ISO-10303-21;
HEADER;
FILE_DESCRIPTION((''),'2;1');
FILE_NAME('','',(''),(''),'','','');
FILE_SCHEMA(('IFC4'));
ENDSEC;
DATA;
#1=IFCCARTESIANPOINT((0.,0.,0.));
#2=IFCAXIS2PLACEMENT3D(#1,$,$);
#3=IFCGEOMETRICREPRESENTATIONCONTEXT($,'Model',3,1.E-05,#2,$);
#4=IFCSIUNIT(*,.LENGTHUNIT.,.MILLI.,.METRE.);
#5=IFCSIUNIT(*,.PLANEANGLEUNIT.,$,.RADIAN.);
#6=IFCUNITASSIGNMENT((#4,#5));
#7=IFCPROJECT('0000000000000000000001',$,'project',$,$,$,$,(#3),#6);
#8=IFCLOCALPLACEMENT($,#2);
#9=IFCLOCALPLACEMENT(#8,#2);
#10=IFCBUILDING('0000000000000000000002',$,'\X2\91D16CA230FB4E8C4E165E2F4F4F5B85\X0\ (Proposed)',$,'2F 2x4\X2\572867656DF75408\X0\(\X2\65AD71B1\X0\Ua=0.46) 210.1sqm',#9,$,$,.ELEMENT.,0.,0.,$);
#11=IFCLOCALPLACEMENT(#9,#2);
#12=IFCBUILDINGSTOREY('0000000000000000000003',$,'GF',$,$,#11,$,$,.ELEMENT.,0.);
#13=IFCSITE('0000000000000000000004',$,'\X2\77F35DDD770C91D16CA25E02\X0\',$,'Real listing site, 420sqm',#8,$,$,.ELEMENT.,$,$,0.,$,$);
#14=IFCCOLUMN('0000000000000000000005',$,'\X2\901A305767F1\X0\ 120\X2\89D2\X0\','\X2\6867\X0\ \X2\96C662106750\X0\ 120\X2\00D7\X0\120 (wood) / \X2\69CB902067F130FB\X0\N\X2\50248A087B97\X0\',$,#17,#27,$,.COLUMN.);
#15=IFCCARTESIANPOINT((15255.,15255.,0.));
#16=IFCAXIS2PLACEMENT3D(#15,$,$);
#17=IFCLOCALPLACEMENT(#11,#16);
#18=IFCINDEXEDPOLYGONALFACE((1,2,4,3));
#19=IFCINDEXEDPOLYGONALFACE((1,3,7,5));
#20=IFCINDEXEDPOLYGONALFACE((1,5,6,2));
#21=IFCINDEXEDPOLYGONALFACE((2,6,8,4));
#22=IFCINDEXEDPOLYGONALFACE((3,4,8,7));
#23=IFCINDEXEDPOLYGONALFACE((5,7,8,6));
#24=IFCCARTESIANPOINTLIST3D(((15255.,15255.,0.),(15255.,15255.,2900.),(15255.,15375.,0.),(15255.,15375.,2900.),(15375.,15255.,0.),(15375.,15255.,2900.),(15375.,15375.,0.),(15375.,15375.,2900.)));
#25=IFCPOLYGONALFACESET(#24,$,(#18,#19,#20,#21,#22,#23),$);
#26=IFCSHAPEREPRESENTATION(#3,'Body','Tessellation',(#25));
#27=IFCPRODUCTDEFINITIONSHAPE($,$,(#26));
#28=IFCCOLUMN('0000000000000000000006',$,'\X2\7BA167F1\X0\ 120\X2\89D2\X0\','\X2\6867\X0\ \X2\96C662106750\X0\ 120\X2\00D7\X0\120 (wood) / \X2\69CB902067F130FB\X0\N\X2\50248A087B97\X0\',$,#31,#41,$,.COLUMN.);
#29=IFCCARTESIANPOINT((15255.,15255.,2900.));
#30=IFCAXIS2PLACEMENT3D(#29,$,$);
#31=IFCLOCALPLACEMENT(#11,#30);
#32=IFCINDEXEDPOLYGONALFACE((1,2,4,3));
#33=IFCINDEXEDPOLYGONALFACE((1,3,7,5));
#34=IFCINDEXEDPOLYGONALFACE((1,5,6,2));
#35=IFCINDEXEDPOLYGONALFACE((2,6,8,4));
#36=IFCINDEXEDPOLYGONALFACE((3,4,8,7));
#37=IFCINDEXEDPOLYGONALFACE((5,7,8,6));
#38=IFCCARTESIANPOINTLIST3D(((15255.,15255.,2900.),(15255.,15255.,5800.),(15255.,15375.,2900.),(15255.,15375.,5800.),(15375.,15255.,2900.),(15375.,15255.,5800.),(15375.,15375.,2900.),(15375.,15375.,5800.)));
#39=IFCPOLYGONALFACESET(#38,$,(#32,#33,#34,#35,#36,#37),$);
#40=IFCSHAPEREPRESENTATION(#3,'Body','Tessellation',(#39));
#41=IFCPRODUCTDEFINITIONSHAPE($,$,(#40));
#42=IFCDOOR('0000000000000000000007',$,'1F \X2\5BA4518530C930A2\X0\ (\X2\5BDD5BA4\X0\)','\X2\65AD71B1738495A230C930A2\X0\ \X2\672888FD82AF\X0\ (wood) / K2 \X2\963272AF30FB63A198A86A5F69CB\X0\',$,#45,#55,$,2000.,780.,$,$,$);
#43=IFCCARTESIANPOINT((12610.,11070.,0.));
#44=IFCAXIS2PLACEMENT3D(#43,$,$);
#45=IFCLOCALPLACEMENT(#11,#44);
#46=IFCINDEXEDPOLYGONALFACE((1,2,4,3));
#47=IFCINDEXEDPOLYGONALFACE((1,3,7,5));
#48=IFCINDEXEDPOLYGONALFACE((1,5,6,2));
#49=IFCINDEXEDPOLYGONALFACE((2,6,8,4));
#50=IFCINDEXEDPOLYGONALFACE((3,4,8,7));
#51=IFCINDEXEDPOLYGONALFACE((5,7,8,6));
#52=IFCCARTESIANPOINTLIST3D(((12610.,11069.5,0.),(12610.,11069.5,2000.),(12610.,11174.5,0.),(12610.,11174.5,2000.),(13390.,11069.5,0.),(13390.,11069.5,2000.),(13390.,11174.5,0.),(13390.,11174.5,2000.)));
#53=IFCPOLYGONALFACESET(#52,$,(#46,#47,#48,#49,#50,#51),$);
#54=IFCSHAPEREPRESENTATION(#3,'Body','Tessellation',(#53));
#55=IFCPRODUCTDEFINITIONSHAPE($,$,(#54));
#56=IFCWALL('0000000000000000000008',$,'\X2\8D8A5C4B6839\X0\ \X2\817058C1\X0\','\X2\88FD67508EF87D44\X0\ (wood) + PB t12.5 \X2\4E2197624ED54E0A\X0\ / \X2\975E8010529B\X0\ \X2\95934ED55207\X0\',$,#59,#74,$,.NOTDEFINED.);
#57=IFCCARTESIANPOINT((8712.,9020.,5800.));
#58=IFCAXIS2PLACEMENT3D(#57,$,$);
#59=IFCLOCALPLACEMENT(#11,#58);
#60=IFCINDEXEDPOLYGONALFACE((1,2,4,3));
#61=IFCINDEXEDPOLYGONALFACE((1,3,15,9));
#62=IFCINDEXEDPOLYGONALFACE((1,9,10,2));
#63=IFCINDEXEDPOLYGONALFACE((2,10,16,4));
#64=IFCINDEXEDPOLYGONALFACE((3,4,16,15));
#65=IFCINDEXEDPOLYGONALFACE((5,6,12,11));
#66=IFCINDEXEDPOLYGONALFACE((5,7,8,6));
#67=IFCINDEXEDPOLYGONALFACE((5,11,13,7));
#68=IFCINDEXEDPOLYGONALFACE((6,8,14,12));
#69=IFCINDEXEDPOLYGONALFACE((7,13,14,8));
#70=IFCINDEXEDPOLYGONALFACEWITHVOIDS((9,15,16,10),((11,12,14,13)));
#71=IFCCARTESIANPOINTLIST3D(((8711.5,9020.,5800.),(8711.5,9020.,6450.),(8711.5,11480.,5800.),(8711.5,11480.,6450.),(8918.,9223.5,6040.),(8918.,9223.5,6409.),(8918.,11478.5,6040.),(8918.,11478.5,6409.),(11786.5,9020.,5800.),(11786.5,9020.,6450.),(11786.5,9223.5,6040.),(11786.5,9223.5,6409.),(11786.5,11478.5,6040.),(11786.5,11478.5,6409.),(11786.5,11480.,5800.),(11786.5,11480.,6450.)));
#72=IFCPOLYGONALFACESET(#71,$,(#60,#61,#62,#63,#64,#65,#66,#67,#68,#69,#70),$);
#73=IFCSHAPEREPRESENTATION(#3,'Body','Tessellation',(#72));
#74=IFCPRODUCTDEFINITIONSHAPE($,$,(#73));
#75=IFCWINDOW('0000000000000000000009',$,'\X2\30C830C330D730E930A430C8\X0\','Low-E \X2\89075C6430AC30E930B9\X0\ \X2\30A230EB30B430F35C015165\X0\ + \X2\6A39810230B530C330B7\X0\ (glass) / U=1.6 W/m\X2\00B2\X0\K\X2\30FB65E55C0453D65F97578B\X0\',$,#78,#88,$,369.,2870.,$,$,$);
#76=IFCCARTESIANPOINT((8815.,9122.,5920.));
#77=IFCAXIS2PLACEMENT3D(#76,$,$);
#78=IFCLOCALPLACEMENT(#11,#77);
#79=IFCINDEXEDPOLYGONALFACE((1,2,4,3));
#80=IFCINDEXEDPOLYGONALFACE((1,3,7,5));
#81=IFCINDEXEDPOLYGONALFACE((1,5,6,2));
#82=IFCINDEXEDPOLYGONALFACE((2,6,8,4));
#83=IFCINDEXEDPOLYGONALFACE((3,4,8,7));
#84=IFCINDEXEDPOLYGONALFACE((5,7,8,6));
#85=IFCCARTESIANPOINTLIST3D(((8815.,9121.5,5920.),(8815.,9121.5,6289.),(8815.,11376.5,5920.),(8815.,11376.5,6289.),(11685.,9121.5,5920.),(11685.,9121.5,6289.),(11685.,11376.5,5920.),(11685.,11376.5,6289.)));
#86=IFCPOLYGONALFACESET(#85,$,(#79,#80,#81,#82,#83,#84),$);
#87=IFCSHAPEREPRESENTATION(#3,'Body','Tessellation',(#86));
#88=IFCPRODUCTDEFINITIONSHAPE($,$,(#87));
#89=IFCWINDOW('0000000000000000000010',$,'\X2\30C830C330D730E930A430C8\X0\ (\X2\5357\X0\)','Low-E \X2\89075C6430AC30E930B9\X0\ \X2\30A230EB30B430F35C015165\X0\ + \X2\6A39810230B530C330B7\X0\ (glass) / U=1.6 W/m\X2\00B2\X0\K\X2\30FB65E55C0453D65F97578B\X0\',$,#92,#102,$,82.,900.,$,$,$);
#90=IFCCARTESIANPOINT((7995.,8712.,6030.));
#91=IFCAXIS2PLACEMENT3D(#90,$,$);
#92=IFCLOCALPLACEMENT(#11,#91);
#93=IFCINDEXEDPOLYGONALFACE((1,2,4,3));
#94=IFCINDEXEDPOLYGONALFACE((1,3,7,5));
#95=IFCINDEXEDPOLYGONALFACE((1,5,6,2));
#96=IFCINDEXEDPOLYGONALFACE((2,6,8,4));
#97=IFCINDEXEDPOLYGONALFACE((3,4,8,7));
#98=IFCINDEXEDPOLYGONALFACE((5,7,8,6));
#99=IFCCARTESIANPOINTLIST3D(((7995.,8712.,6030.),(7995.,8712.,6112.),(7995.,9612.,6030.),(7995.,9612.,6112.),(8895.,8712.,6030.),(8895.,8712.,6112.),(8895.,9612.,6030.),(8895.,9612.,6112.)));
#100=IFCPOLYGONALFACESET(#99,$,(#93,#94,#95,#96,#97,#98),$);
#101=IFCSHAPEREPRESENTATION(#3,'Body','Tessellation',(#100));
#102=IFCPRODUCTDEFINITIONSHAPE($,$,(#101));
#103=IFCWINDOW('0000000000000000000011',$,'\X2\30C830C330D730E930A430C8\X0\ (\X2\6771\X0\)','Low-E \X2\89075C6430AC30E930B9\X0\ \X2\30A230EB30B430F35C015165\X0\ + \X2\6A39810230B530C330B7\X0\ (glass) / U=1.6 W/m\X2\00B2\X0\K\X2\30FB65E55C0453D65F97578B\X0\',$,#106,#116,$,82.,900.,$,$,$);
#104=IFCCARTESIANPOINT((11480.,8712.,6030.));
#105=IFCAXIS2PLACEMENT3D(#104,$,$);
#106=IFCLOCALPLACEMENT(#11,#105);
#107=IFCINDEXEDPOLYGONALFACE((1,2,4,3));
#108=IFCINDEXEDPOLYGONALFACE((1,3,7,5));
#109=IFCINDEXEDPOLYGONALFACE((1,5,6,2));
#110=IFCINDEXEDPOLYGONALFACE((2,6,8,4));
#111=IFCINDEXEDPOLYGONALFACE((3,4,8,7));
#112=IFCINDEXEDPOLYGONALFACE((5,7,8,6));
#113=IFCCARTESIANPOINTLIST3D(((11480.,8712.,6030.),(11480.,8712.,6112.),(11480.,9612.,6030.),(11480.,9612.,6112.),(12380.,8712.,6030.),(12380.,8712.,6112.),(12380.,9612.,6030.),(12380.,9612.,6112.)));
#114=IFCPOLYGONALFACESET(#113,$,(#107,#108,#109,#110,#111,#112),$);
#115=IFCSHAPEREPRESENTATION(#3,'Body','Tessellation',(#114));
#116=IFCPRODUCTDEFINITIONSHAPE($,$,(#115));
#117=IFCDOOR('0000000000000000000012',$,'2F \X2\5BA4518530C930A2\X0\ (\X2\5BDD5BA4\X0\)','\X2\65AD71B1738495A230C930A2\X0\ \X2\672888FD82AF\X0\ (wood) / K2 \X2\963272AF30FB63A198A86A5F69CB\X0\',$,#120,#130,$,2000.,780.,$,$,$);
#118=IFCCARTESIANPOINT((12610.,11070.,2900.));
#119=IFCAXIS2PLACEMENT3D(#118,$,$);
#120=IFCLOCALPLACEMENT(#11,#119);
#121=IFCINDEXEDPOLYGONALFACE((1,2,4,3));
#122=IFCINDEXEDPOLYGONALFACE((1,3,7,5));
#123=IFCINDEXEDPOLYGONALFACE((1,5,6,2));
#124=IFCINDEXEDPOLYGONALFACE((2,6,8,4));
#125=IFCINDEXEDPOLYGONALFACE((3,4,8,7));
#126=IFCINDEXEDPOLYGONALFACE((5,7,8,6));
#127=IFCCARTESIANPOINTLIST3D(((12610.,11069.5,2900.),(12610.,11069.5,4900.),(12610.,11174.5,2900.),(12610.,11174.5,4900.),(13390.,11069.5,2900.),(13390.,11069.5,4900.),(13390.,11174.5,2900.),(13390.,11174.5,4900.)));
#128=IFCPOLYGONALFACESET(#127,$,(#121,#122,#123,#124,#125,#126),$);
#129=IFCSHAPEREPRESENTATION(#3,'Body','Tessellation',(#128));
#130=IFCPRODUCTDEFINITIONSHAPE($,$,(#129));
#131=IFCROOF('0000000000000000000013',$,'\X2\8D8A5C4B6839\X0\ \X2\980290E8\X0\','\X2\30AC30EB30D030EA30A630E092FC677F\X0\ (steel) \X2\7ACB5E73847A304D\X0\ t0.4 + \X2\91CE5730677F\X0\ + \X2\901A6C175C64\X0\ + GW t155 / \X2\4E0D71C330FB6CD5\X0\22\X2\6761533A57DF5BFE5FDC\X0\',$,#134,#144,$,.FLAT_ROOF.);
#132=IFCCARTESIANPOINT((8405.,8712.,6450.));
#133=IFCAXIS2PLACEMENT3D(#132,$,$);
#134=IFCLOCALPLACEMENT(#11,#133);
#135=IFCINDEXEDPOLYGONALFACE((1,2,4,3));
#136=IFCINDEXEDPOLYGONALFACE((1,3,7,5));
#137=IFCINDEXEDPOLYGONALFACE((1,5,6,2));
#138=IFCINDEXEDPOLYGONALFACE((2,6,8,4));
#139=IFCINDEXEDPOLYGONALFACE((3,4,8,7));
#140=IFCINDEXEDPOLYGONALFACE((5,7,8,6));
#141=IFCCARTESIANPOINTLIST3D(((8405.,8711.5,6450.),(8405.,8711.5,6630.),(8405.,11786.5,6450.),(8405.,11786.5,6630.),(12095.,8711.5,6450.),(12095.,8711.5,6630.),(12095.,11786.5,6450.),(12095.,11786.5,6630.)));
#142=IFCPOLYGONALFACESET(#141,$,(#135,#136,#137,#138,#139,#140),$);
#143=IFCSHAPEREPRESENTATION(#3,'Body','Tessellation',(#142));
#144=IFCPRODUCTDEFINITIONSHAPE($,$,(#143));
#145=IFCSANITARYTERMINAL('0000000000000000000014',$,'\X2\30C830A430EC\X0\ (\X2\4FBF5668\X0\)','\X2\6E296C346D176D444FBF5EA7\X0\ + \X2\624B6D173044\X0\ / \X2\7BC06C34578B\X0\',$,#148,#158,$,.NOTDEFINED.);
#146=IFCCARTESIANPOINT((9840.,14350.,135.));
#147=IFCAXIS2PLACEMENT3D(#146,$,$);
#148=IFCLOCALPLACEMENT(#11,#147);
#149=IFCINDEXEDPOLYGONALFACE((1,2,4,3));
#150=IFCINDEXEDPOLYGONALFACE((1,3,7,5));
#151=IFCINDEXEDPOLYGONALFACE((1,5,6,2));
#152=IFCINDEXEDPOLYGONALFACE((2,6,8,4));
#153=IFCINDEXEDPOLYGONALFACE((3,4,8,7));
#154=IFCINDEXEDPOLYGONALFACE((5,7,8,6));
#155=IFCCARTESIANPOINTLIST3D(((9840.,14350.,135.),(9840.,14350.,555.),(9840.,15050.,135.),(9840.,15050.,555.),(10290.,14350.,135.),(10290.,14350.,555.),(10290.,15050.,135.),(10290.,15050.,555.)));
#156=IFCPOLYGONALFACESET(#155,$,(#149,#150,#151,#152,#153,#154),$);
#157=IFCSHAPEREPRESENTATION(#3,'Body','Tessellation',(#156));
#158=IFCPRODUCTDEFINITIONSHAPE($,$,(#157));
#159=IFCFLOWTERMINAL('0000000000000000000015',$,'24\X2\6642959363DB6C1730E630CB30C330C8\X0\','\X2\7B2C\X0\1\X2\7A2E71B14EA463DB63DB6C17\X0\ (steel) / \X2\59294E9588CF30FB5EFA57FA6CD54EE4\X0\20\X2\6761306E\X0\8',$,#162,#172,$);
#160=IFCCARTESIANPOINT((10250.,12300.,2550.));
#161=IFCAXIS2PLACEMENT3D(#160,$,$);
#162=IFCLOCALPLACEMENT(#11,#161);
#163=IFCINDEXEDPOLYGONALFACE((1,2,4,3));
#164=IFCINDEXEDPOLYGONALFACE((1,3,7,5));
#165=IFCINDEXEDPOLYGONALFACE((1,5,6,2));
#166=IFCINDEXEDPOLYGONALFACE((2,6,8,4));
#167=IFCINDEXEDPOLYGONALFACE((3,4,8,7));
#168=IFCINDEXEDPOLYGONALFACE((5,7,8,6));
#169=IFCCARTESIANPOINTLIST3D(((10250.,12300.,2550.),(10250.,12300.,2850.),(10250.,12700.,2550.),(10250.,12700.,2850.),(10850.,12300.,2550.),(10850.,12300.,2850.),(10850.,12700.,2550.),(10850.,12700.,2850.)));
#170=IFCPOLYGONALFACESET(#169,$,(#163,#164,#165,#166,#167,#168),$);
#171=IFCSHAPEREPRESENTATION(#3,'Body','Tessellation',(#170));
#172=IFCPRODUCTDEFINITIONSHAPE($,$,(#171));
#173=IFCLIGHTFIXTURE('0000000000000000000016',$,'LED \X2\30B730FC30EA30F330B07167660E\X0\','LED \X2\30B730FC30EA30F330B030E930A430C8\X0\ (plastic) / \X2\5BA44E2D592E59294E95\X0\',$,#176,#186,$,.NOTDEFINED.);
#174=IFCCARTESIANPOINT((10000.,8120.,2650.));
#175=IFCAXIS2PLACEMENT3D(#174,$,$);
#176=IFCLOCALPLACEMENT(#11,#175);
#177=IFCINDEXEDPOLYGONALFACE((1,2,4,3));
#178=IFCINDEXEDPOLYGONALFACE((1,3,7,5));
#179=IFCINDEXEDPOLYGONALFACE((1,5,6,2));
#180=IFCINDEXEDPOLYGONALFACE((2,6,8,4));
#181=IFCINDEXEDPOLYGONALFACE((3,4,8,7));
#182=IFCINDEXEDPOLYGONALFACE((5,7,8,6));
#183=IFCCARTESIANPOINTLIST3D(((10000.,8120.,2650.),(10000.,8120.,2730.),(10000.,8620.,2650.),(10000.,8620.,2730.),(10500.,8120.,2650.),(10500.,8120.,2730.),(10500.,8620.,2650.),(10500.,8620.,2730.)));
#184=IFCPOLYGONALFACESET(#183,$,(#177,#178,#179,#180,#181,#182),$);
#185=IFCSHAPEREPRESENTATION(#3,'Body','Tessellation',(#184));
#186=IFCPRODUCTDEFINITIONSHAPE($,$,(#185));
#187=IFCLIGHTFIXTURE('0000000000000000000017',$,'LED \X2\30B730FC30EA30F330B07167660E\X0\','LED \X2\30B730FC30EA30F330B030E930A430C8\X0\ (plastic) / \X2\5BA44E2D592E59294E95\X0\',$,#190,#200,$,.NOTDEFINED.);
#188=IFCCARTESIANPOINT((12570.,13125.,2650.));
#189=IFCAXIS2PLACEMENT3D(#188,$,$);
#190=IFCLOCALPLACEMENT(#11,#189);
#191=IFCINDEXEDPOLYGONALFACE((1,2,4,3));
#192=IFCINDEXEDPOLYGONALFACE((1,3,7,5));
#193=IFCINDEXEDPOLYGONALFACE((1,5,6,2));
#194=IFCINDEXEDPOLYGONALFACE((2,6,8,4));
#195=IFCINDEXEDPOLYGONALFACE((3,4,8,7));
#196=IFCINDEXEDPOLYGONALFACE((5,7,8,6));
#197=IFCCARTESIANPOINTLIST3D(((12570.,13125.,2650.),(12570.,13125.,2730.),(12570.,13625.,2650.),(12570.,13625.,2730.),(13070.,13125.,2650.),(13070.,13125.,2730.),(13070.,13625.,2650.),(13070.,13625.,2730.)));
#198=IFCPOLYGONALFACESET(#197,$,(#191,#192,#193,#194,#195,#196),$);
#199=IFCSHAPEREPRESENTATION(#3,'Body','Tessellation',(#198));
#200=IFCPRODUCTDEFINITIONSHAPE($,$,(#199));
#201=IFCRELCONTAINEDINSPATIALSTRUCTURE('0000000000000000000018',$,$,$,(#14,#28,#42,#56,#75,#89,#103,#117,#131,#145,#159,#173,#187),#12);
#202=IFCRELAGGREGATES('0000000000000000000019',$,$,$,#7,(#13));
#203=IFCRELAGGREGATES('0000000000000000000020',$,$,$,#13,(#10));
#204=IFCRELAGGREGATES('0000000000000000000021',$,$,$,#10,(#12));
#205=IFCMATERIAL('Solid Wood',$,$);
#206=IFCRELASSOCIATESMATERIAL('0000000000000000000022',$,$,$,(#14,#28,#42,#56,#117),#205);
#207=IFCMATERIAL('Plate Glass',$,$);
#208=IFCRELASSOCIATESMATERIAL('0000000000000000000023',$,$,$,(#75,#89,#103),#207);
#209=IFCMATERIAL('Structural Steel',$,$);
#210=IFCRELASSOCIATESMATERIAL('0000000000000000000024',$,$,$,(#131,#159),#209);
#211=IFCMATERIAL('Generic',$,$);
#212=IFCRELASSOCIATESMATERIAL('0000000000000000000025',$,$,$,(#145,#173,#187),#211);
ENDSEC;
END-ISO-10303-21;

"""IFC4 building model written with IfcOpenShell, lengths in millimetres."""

from ifc_helpers import new_model, si_unit, frame, frame_2d, origin, place, context, project, spatial, rectangle, extrude, material, element, fill, save


model = new_model("IFC4")

# Units and contexts
model_context = context("Model", 3, precision=1e-05, world=origin())
ifc_project = project(units=[si_unit("LENGTHUNIT", "METRE", prefix="MILLI"), si_unit("PLANEANGLEUNIT", "RADIAN")], contexts=[model_context])

# Site, building, storey
site_placement = place(None, origin())
site = spatial("IfcSite", under=ifc_project, at=site_placement, Name="石川県金沢市", ObjectType="Real listing site, 420sqm", CompositionType="ELEMENT", RefElevation=0.0)
building_placement = place(site_placement, origin())
building = spatial("IfcBuilding", under=site, at=building_placement, Name="金沢・二世帯住宅 (Proposed)", ObjectType="2F 2x4在来混合(断熱Ua=0.46) 210.1sqm", CompositionType="ELEMENT", ElevationOfRefHeight=0.0, ElevationOfTerrain=0.0)
storey_placement = place(building_placement, origin())
storey = spatial("IfcBuildingStorey", under=building, at=storey_placement, Name="GF", CompositionType="ELEMENT", Elevation=0.0)

# Columns
ifc_material_1 = material(Name="Solid Wood")
column_1_placement = place(storey_placement, frame((15255.0, 15255.0, 0.0)))
element("IfcColumn", 1, at=column_1_placement, inside=storey, material=ifc_material_1, Name="通し柱 120角", Description="桧 集成材 120×120 (wood) / 構造柱・N値計算", PredefinedType="COLUMN", context=model_context, shape_type="SweptSolid", body=[
    extrude(rectangle(XDim=120.0, YDim=120.0, at=frame_2d((60.0, 60.0))), frame((15255.0, 15255.0, 0.0)), (0.0, 0.0, 1.0), 2900.0),
])
column_2_placement = place(storey_placement, frame((15255.0, 15255.0, 2900.0)))
element("IfcColumn", 2, at=column_2_placement, inside=storey, material=ifc_material_1, Name="管柱 120角", Description="桧 集成材 120×120 (wood) / 構造柱・N値計算", PredefinedType="COLUMN", context=model_context, shape_type="SweptSolid", body=[
    extrude(rectangle(XDim=120.0, YDim=120.0, at=frame_2d((60.0, 60.0))), frame((15255.0, 15255.0, 2900.0)), (0.0, 0.0, 1.0), 2900.0),
])

# Door
door_1_placement = place(storey_placement, frame((12610.0, 11070.0, 0.0)))
element("IfcDoor", 3, at=door_1_placement, inside=storey, material=ifc_material_1, Name="1F 室内ドア (寝室)", Description="断熱玄関ドア 木製芯 (wood) / K2 防犯・採風機構", OverallHeight=2000.0, OverallWidth=780.0, context=model_context, shape_type="SweptSolid", body=[
    extrude(rectangle(XDim=780.0, YDim=105.0, at=frame_2d((390.0, 52.0))), frame((12610.0, 11070.0, 0.0)), (0.0, 0.0, 1.0), 2000.0),
])

# Wall, openings, windows
wall_1_placement = place(storey_placement, frame((8712.0, 9020.0, 5800.0)))
wall_1 = element("IfcWall", 4, at=wall_1_placement, inside=storey, material=ifc_material_1, Name="越屋根 腰壁", Description="製材軸組 (wood) + PB t12.5 両面仕上 / 非耐力 間仕切", PredefinedType="NOTDEFINED", context=model_context, shape_type="SweptSolid", body=[
    extrude(rectangle(XDim=3075.0, YDim=2460.0, at=frame_2d((1537.0, 1230.0))), frame((8712.0, 9020.0, 5800.0)), (0.0, 0.0, 1.0), 650.0),
])
opening_1_placement = place(storey_placement, frame((8815.0, 9122.0, 5920.0)))
opening_1 = element("IfcOpeningElement", 5, at=opening_1_placement, cuts=wall_1, PredefinedType="NOTDEFINED", context=model_context, shape_type="SweptSolid", body=[
    extrude(rectangle(XDim=2870.0, YDim=2255.0, at=frame_2d((1435.0, 1127.0))), frame((8815.0, 9122.0, 5920.0)), (0.0, 0.0, 1.0), 369.0),
])
opening_2_placement = place(storey_placement, frame((7995.0, 8712.0, 6030.0)))
opening_2 = element("IfcOpeningElement", 6, at=opening_2_placement, cuts=wall_1, PredefinedType="NOTDEFINED", context=model_context, shape_type="SweptSolid", body=[
    extrude(rectangle(XDim=900.0, YDim=900.0, at=frame_2d((450.0, 450.0))), frame((7995.0, 8712.0, 6030.0)), (0.0, 0.0, 1.0), 82.0),
])
opening_3_placement = place(storey_placement, frame((11480.0, 8712.0, 6030.0)))
opening_3 = element("IfcOpeningElement", 7, at=opening_3_placement, cuts=wall_1, PredefinedType="NOTDEFINED", context=model_context, shape_type="SweptSolid", body=[
    extrude(rectangle(XDim=900.0, YDim=900.0, at=frame_2d((450.0, 450.0))), frame((11480.0, 8712.0, 6030.0)), (0.0, 0.0, 1.0), 82.0),
])
ifc_material_2 = material(Name="Plate Glass")
window_1_placement = place(storey_placement, frame((8815.0, 9122.0, 5920.0)))
window_1 = element("IfcWindow", 8, at=window_1_placement, inside=storey, material=ifc_material_2, Name="トップライト", Description="Low-E 複層ガラス アルゴン封入 + 樹脂サッシ (glass) / U=1.6 W/m²K・日射取得型", OverallHeight=369.0, OverallWidth=2870.0, context=model_context, shape_type="SweptSolid", body=[
    extrude(rectangle(XDim=2870.0, YDim=2255.0, at=frame_2d((1435.0, 1127.0))), frame((8815.0, 9122.0, 5920.0)), (0.0, 0.0, 1.0), 369.0),
])
fill(opening_1, window_1)
window_2_placement = place(storey_placement, frame((7995.0, 8712.0, 6030.0)))
window_2 = element("IfcWindow", 9, at=window_2_placement, inside=storey, material=ifc_material_2, Name="トップライト (南)", Description="Low-E 複層ガラス アルゴン封入 + 樹脂サッシ (glass) / U=1.6 W/m²K・日射取得型", OverallHeight=82.0, OverallWidth=900.0, context=model_context, shape_type="SweptSolid", body=[
    extrude(rectangle(XDim=900.0, YDim=900.0, at=frame_2d((450.0, 450.0))), frame((7995.0, 8712.0, 6030.0)), (0.0, 0.0, 1.0), 82.0),
])
fill(opening_2, window_2)
window_3_placement = place(storey_placement, frame((11480.0, 8712.0, 6030.0)))
window_3 = element("IfcWindow", 10, at=window_3_placement, inside=storey, material=ifc_material_2, Name="トップライト (東)", Description="Low-E 複層ガラス アルゴン封入 + 樹脂サッシ (glass) / U=1.6 W/m²K・日射取得型", OverallHeight=82.0, OverallWidth=900.0, context=model_context, shape_type="SweptSolid", body=[
    extrude(rectangle(XDim=900.0, YDim=900.0, at=frame_2d((450.0, 450.0))), frame((11480.0, 8712.0, 6030.0)), (0.0, 0.0, 1.0), 82.0),
])
fill(opening_3, window_3)

# Door
door_2_placement = place(storey_placement, frame((12610.0, 11070.0, 2900.0)))
element("IfcDoor", 11, at=door_2_placement, inside=storey, material=ifc_material_1, Name="2F 室内ドア (寝室)", Description="断熱玄関ドア 木製芯 (wood) / K2 防犯・採風機構", OverallHeight=2000.0, OverallWidth=780.0, context=model_context, shape_type="SweptSolid", body=[
    extrude(rectangle(XDim=780.0, YDim=105.0, at=frame_2d((390.0, 52.0))), frame((12610.0, 11070.0, 2900.0)), (0.0, 0.0, 1.0), 2000.0),
])

# Roof
ifc_material_3 = material(Name="Structural Steel")
roof_placement = place(storey_placement, frame((8405.0, 8712.0, 6450.0)))
element("IfcRoof", 12, at=roof_placement, inside=storey, material=ifc_material_3, Name="越屋根 頂部", Description="ガルバリウム鋼板 (steel) 立平葺き t0.4 + 野地板 + 通気層 + GW t155 / 不燃・法22条区域対応", PredefinedType="FLAT_ROOF", context=model_context, shape_type="SweptSolid", body=[
    extrude(rectangle(XDim=3690.0, YDim=3075.0, at=frame_2d((1845.0, 1537.0))), frame((8405.0, 8712.0, 6450.0)), (0.0, 0.0, 1.0), 180.0),
])

# Sanitary terminal
ifc_material_4 = material(Name="Generic")
sanitary_terminal_placement = place(storey_placement, frame((9840.0, 14350.0, 135.0)))
element("IfcSanitaryTerminal", 13, at=sanitary_terminal_placement, inside=storey, material=ifc_material_4, Name="トイレ (便器)", Description="温水洗浄便座 + 手洗い / 節水型", PredefinedType="NOTDEFINED", context=model_context, shape_type="SweptSolid", body=[
    extrude(rectangle(XDim=450.0, YDim=700.0, at=frame_2d((225.0, 350.0))), frame((9840.0, 14350.0, 135.0)), (0.0, 0.0, 1.0), 420.0),
])

# Flow terminal
flow_terminal_placement = place(storey_placement, frame((10250.0, 12300.0, 2550.0)))
element("IfcFlowTerminal", 14, at=flow_terminal_placement, inside=storey, material=ifc_material_3, Name="24時間換気ユニット", Description="第1種熱交換換気 (steel) / 天井裏・建基法令20条の8", context=model_context, shape_type="SweptSolid", body=[
    extrude(rectangle(XDim=600.0, YDim=400.0, at=frame_2d((300.0, 200.0))), frame((10250.0, 12300.0, 2550.0)), (0.0, 0.0, 1.0), 300.0),
])

# Light fixtures
light_fixture_1_placement = place(storey_placement, frame((10000.0, 8120.0, 2650.0)))
element("IfcLightFixture", 15, at=light_fixture_1_placement, inside=storey, material=ifc_material_4, Name="LED シーリング照明", Description="LED シーリングライト (plastic) / 室中央天井", PredefinedType="NOTDEFINED", context=model_context, shape_type="SweptSolid", body=[
    extrude(rectangle(XDim=500.0, YDim=500.0, at=frame_2d((250.0, 250.0))), frame((10000.0, 8120.0, 2650.0)), (0.0, 0.0, 1.0), 80.0),
])
light_fixture_2_placement = place(storey_placement, frame((12570.0, 13125.0, 2650.0)))
element("IfcLightFixture", 16, at=light_fixture_2_placement, inside=storey, material=ifc_material_4, Name="LED シーリング照明", Description="LED シーリングライト (plastic) / 室中央天井", PredefinedType="NOTDEFINED", context=model_context, shape_type="SweptSolid", body=[
    extrude(rectangle(XDim=500.0, YDim=500.0, at=frame_2d((250.0, 250.0))), frame((12570.0, 13125.0, 2650.0)), (0.0, 0.0, 1.0), 80.0),
])

save(model, "model.ifc")
